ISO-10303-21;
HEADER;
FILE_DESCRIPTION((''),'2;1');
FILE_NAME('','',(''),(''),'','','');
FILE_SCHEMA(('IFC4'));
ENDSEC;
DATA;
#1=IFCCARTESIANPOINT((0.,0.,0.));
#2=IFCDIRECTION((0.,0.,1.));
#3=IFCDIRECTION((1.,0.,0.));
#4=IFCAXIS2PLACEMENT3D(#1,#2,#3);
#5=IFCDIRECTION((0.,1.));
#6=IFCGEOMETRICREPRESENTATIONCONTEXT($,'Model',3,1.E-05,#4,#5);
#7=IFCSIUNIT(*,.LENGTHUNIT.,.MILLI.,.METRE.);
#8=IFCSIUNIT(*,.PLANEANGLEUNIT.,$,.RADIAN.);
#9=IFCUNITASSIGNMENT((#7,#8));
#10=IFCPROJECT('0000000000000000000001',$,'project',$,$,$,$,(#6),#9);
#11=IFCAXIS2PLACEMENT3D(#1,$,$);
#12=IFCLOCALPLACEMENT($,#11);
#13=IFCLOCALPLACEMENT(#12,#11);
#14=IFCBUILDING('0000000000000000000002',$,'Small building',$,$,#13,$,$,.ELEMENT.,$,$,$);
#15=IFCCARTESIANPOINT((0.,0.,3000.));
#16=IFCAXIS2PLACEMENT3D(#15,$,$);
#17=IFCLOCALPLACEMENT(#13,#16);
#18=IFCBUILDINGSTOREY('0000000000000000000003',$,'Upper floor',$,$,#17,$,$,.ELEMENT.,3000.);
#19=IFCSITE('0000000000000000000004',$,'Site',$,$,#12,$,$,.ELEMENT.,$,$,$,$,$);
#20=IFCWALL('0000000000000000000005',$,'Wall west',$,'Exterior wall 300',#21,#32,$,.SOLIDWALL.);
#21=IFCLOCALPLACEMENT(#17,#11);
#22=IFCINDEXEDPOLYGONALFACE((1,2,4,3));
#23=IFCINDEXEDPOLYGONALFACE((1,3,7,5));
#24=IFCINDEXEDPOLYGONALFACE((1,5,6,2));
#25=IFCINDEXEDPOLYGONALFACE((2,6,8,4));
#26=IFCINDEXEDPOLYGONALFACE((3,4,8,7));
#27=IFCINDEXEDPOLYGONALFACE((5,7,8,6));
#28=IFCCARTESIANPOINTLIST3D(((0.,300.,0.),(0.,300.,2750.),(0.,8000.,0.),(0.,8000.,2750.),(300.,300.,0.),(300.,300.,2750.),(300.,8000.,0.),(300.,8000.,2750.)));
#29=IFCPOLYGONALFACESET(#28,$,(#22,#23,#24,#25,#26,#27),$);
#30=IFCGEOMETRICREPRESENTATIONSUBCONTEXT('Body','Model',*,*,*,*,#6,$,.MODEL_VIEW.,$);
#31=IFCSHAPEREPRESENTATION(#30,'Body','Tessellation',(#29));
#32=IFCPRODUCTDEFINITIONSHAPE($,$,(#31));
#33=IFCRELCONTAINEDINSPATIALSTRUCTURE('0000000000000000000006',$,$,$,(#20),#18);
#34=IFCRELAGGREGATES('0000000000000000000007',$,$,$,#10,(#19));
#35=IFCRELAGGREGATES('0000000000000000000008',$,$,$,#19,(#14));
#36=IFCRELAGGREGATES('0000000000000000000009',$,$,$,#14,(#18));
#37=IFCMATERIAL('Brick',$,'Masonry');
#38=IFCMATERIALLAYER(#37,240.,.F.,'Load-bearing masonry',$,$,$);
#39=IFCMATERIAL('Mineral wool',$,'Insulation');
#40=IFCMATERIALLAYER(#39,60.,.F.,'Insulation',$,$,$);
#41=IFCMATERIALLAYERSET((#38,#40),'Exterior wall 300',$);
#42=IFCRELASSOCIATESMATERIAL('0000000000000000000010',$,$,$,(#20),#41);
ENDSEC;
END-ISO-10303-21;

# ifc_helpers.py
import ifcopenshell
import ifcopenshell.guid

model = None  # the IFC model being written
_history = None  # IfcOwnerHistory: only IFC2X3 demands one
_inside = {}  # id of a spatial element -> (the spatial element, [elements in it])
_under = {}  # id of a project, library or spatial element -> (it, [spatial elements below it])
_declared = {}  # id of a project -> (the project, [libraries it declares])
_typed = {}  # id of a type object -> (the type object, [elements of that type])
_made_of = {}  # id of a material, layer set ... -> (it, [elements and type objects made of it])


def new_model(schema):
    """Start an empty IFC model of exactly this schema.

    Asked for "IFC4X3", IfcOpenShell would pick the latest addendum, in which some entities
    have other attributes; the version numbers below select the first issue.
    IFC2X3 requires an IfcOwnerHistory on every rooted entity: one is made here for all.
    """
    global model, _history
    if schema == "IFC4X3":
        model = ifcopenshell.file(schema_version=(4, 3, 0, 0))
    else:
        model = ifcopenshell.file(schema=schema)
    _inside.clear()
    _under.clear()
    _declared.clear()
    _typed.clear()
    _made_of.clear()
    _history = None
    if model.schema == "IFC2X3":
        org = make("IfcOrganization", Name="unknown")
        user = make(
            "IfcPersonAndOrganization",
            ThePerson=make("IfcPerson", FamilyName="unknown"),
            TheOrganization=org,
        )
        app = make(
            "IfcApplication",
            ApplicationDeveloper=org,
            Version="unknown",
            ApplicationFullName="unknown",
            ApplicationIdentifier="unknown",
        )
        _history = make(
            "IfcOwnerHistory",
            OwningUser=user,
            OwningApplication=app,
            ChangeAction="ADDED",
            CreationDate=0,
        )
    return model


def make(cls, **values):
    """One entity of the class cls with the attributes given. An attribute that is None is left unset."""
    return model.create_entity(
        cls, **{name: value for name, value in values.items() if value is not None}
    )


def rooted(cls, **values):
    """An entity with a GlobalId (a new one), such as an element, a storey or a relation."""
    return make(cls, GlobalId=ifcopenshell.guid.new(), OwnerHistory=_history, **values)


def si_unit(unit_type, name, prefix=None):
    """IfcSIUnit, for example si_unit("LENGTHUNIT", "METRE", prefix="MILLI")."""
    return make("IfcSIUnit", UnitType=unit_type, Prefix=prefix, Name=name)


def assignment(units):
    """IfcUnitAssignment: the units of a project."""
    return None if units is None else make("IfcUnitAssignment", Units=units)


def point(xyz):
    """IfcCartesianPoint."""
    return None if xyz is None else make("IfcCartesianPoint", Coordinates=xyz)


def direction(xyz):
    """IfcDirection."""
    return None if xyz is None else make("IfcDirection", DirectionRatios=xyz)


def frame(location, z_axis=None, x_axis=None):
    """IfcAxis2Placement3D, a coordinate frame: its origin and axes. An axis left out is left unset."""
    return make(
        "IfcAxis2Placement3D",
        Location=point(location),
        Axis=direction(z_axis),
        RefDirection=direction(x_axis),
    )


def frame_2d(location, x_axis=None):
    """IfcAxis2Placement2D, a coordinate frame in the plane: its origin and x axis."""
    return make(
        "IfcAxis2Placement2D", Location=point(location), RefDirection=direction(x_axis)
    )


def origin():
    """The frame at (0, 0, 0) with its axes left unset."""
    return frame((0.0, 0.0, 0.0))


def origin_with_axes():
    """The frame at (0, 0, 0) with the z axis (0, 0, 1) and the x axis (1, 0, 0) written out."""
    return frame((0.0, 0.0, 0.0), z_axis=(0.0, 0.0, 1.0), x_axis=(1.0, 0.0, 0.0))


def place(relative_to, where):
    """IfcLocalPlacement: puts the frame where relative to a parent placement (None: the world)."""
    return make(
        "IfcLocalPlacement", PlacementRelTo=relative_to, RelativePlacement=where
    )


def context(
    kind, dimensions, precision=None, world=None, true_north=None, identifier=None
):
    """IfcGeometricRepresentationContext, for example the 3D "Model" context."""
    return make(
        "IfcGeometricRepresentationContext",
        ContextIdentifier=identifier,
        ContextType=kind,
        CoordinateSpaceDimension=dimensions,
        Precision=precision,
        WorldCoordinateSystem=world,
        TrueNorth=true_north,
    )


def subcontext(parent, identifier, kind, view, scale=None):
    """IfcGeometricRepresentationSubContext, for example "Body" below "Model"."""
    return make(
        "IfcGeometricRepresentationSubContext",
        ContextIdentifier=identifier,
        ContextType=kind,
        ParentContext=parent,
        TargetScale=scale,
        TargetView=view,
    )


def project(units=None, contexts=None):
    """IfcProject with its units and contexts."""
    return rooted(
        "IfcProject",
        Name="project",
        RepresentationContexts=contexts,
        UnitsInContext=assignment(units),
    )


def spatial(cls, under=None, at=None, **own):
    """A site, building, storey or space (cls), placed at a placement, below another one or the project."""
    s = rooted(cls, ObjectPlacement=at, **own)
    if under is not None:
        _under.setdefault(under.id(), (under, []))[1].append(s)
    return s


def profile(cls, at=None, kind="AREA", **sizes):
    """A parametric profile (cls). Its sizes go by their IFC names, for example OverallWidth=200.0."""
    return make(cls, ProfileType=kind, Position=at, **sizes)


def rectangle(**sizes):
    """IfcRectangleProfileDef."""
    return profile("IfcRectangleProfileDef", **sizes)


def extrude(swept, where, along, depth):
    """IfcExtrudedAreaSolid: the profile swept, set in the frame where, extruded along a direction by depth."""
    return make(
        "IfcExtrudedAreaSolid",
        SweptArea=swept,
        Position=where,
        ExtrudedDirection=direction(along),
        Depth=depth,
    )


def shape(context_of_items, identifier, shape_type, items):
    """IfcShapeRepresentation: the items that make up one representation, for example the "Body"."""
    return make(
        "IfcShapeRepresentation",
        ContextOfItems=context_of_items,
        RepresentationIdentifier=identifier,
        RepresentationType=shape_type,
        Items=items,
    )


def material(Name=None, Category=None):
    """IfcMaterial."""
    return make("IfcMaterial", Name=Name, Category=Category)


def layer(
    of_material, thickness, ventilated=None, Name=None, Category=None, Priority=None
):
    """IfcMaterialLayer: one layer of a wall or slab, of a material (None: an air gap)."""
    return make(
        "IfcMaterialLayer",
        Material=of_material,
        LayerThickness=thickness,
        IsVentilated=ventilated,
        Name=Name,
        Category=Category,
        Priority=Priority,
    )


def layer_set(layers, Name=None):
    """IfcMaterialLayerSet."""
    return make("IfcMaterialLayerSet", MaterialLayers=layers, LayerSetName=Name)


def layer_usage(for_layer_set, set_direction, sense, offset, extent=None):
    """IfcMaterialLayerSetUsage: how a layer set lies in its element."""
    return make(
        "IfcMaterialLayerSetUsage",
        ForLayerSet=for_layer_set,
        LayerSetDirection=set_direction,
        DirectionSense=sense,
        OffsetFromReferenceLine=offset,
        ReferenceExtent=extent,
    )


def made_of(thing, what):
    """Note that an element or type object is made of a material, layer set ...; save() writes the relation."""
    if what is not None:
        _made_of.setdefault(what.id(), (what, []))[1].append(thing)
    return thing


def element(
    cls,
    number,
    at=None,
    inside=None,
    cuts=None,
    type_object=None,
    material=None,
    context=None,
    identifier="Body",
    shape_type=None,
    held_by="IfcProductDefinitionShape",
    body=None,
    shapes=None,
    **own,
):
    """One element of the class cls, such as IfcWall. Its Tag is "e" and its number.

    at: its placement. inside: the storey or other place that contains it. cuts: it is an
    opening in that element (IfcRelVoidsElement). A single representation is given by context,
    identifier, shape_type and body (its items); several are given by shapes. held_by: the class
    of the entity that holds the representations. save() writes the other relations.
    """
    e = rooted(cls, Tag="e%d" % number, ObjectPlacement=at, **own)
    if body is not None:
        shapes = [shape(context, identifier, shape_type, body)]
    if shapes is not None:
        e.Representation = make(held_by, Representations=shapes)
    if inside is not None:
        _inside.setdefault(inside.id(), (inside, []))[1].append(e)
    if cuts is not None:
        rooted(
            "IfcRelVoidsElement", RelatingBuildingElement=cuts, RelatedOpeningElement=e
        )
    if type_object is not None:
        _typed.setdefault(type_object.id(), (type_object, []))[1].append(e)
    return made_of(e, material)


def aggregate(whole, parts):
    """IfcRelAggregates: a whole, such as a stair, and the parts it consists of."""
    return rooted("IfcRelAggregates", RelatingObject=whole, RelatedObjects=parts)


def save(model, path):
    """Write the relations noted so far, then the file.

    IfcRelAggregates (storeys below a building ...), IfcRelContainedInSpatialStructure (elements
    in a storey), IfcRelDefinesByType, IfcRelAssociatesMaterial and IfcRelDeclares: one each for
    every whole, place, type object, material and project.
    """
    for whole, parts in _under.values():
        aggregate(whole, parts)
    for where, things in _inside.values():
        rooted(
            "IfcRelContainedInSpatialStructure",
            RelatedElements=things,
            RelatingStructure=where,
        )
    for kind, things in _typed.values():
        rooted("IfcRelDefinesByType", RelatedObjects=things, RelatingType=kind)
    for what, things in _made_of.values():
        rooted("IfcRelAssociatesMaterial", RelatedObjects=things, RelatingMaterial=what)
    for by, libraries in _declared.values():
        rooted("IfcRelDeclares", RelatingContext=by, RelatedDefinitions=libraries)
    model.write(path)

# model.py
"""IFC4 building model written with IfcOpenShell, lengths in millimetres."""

from ifc_helpers import new_model, si_unit, direction, frame, frame_2d, origin, origin_with_axes, place, context, subcontext, project, spatial, rectangle, extrude, material, layer, layer_set, layer_usage, element, save


model = new_model("IFC4")

# Units and contexts
model_context = context("Model", 3, precision=1e-05, world=origin_with_axes(), true_north=direction((0.0, 1.0)))
body_context = subcontext(model_context, "Body", "Model", "MODEL_VIEW")
ifc_project = project(units=[si_unit("LENGTHUNIT", "METRE", prefix="MILLI"), si_unit("PLANEANGLEUNIT", "RADIAN")], contexts=[model_context])

# Site, building, storey
site_placement = place(None, origin())
site = spatial("IfcSite", under=ifc_project, at=site_placement, Name="Site", CompositionType="ELEMENT")
building_placement = place(site_placement, origin())
building = spatial("IfcBuilding", under=site, at=building_placement, Name="Small building", CompositionType="ELEMENT")
storey_placement = place(building_placement, frame((0.0, 0.0, 3000.0)))
storey = spatial("IfcBuildingStorey", under=building, at=storey_placement, Name="Upper floor", CompositionType="ELEMENT", Elevation=3000.0)

# Shared definitions
ifc_material_1 = material(Name="Brick", Category="Masonry")
ifc_layer_1 = layer(ifc_material_1, 240.0, ventilated=False, Name="Load-bearing masonry")
ifc_material_2 = material(Name="Mineral wool", Category="Insulation")
ifc_layer_2 = layer(ifc_material_2, 60.0, ventilated=False, Name="Insulation")
ifc_layer_set = layer_set([ifc_layer_1, ifc_layer_2], Name="Exterior wall 300")

# Wall
ifc_layer_usage_1 = layer_usage(ifc_layer_set, "AXIS2", "POSITIVE", 0.0)
wall_1_placement = place(storey_placement, frame((0.0, 8000.0, 0.0), x_axis=(0.0, -1.0, 0.0)))
element("IfcWall", 1, at=wall_1_placement, inside=storey, material=ifc_layer_usage_1, Name="Wall west", ObjectType="Exterior wall 300", PredefinedType="SOLIDWALL", context=body_context, shape_type="SweptSolid", body=[
    extrude(rectangle(XDim=7700.0, YDim=300.0, at=frame_2d((3850.0, 150.0))), origin_with_axes(), (0.0, 0.0, 1.0), 2750.0),
])

save(model, "model.ifc")
